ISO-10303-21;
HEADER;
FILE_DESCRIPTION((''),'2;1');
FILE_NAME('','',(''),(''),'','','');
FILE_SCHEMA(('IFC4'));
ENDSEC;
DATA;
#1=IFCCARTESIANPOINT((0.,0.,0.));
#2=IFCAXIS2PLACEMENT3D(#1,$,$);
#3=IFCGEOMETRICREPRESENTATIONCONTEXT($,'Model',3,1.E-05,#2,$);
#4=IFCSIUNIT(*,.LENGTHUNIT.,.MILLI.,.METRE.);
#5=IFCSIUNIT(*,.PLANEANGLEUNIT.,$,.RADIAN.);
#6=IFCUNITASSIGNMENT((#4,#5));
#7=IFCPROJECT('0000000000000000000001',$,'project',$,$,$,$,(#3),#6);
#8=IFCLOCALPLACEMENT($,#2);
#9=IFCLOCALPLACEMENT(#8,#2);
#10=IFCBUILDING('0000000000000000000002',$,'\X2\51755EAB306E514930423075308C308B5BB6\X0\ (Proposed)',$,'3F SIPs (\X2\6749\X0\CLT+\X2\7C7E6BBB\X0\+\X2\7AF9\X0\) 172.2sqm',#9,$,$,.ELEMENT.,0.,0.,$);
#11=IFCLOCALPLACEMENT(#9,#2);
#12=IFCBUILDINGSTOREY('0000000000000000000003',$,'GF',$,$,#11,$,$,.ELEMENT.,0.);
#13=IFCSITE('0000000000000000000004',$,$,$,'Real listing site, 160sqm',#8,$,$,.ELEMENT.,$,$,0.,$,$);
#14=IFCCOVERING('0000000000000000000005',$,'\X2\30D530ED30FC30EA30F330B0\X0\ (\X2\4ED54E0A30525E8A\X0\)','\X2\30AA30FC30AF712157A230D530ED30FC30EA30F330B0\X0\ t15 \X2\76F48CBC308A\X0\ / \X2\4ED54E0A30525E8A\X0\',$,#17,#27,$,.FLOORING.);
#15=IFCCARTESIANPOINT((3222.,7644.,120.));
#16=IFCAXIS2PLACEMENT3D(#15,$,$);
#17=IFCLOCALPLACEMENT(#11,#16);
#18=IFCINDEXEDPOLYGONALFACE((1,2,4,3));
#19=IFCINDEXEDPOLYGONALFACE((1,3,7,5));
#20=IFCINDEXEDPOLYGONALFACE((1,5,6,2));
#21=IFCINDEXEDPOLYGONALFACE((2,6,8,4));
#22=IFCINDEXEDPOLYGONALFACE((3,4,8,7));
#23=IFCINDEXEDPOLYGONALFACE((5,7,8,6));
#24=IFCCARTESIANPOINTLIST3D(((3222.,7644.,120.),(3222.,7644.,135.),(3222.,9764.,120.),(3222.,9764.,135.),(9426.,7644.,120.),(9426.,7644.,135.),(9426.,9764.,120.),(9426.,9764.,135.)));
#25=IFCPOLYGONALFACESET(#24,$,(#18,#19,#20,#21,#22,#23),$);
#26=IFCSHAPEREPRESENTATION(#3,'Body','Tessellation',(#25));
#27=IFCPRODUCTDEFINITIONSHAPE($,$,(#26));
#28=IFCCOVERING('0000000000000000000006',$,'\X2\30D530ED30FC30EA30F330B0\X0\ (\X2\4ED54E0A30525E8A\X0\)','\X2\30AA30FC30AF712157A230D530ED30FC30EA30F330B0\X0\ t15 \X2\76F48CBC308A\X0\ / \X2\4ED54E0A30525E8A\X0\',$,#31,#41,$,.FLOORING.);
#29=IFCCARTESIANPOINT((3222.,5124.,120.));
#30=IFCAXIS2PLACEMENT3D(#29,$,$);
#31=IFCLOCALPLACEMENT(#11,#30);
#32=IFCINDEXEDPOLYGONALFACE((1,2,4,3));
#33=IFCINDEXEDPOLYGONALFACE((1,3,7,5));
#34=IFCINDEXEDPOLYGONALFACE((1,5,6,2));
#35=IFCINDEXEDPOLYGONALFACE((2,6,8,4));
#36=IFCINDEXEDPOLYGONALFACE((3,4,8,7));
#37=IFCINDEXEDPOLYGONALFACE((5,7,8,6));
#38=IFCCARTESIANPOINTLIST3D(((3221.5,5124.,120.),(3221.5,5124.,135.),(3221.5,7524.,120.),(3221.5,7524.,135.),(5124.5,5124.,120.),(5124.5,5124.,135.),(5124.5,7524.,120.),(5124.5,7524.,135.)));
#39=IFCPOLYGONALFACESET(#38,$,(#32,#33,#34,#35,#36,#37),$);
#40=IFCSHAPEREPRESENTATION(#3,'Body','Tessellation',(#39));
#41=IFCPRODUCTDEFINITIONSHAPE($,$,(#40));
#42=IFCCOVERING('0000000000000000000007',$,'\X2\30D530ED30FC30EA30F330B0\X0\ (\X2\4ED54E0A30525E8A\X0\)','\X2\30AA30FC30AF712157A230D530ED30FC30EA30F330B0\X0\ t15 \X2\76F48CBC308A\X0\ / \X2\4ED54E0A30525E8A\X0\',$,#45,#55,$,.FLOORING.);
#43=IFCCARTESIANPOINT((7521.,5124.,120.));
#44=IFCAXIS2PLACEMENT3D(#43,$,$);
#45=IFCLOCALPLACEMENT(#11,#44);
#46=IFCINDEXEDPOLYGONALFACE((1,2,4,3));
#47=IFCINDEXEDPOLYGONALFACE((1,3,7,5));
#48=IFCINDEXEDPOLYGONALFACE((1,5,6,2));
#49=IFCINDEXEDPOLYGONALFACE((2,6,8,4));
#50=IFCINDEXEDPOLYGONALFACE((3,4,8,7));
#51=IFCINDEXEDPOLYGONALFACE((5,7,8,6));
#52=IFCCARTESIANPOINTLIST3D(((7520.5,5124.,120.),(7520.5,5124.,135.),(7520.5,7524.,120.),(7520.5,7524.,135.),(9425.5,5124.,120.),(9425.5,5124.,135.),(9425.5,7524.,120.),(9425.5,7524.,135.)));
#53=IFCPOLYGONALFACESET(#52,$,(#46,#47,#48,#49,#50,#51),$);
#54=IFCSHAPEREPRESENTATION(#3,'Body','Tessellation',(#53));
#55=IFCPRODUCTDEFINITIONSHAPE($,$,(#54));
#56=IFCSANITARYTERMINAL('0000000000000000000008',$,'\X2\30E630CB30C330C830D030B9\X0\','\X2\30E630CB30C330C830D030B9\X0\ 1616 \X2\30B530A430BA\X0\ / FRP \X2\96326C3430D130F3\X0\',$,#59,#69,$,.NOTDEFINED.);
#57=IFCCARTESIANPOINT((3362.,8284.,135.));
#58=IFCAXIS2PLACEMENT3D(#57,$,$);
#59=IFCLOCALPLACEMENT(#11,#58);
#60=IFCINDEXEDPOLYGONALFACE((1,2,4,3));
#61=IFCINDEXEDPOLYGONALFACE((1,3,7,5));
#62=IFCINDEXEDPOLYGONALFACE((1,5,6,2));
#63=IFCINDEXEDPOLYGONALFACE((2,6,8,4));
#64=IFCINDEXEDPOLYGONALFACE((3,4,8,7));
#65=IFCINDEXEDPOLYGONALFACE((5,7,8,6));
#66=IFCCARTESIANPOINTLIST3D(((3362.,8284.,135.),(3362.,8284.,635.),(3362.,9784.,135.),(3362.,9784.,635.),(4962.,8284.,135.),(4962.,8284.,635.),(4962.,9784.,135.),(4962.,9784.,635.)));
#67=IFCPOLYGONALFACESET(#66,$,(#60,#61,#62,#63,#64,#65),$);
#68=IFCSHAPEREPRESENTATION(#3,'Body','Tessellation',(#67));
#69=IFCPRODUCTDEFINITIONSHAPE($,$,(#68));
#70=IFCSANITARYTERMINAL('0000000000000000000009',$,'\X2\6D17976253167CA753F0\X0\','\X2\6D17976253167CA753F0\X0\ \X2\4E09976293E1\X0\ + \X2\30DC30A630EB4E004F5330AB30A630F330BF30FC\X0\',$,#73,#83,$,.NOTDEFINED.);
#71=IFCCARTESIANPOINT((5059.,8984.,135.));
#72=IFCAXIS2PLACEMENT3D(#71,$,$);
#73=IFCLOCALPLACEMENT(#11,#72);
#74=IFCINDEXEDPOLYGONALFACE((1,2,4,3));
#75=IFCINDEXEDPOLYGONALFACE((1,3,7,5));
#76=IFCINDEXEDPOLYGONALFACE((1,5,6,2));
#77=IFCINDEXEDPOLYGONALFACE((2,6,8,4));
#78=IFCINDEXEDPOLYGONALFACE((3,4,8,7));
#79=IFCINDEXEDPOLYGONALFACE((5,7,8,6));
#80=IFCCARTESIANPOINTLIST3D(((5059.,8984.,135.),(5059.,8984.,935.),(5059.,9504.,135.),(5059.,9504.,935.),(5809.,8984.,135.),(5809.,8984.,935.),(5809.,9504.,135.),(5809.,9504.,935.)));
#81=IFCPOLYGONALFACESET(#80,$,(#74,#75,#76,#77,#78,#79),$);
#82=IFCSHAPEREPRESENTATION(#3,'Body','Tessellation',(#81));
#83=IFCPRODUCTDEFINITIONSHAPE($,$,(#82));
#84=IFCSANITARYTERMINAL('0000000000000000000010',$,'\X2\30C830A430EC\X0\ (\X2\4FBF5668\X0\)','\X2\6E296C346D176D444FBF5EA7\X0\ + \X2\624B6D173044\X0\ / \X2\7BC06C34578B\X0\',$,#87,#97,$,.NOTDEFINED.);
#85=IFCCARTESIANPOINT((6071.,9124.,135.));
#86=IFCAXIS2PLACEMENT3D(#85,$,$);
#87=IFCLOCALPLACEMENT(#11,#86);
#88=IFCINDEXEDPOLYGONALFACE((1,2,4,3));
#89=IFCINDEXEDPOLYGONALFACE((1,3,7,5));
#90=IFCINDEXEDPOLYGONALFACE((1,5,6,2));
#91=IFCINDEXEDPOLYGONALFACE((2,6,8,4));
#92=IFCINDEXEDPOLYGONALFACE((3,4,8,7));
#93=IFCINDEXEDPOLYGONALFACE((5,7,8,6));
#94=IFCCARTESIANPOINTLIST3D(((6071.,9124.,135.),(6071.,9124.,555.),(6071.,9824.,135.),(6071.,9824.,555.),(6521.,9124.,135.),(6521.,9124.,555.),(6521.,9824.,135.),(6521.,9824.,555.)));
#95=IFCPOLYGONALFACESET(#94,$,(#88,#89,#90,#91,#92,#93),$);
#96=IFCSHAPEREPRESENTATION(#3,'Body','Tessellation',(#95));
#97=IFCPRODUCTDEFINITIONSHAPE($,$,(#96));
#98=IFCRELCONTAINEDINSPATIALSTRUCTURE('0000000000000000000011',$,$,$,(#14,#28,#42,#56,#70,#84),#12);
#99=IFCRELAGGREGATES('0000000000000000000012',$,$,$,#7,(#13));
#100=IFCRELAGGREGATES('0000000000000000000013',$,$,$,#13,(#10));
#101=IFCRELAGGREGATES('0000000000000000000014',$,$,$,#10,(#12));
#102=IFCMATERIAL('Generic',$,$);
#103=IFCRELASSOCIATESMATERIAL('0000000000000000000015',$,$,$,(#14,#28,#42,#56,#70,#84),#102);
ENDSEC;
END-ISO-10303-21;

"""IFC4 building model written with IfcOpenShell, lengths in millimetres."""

from ifc_helpers import new_model, si_unit, frame, frame_2d, origin, place, context, project, spatial, rectangle, extrude, material, element, save


model = new_model("IFC4")

# Units and contexts
model_context = context("Model", 3, precision=1e-05, world=origin())
ifc_project = project(units=[si_unit("LENGTHUNIT", "METRE", prefix="MILLI"), si_unit("PLANEANGLEUNIT", "RADIAN")], contexts=[model_context])

# Site, building, storey
site_placement = place(None, origin())
site = spatial("IfcSite", under=ifc_project, at=site_placement, ObjectType="Real listing site, 160sqm", CompositionType="ELEMENT", RefElevation=0.0)
building_placement = place(site_placement, origin())
building = spatial("IfcBuilding", under=site, at=building_placement, Name="兵庫の光あふれる家 (Proposed)", ObjectType="3F SIPs (杉CLT+籾殻+竹) 172.2sqm", CompositionType="ELEMENT", ElevationOfRefHeight=0.0, ElevationOfTerrain=0.0)
storey_placement = place(building_placement, origin())
storey = spatial("IfcBuildingStorey", under=building, at=storey_placement, Name="GF", CompositionType="ELEMENT", Elevation=0.0)

# Coverings
ifc_material_1 = material(Name="Generic")
covering_1_placement = place(storey_placement, frame((3222.0, 7644.0, 120.0)))
element("IfcCovering", 1, at=covering_1_placement, inside=storey, material=ifc_material_1, Name="フローリング (仕上げ床)", Description="オーク無垢フローリング t15 直貼り / 仕上げ床", PredefinedType="FLOORING", context=model_context, shape_type="SweptSolid", body=[
    extrude(rectangle(XDim=6204.0, YDim=2120.0, at=frame_2d((3102.0, 1060.0))), frame((3222.0, 7644.0, 120.0)), (0.0, 0.0, 1.0), 15.0),
])
covering_2_placement = place(storey_placement, frame((3222.0, 5124.0, 120.0)))
element("IfcCovering", 2, at=covering_2_placement, inside=storey, material=ifc_material_1, Name="フローリング (仕上げ床)", Description="オーク無垢フローリング t15 直貼り / 仕上げ床", PredefinedType="FLOORING", context=model_context, shape_type="SweptSolid", body=[
    extrude(rectangle(XDim=1903.0, YDim=2400.0, at=frame_2d((951.0, 1200.0))), frame((3222.0, 5124.0, 120.0)), (0.0, 0.0, 1.0), 15.0),
])
covering_3_placement = place(storey_placement, frame((7521.0, 5124.0, 120.0)))
element("IfcCovering", 3, at=covering_3_placement, inside=storey, material=ifc_material_1, Name="フローリング (仕上げ床)", Description="オーク無垢フローリング t15 直貼り / 仕上げ床", PredefinedType="FLOORING", context=model_context, shape_type="SweptSolid", body=[
    extrude(rectangle(XDim=1905.0, YDim=2400.0, at=frame_2d((952.0, 1200.0))), frame((7521.0, 5124.0, 120.0)), (0.0, 0.0, 1.0), 15.0),
])

# Sanitary terminals
sanitary_terminal_1_placement = place(storey_placement, frame((3362.0, 8284.0, 135.0)))
element("IfcSanitaryTerminal", 4, at=sanitary_terminal_1_placement, inside=storey, material=ifc_material_1, Name="ユニットバス", Description="ユニットバス 1616 サイズ / FRP 防水パン", PredefinedType="NOTDEFINED", context=model_context, shape_type="SweptSolid", body=[
    extrude(rectangle(XDim=1600.0, YDim=1500.0, at=frame_2d((800.0, 750.0))), frame((3362.0, 8284.0, 135.0)), (0.0, 0.0, 1.0), 500.0),
])
sanitary_terminal_2_placement = place(storey_placement, frame((5059.0, 8984.0, 135.0)))
element("IfcSanitaryTerminal", 5, at=sanitary_terminal_2_placement, inside=storey, material=ifc_material_1, Name="洗面化粧台", Description="洗面化粧台 三面鏡 + ボウル一体カウンター", PredefinedType="NOTDEFINED", context=model_context, shape_type="SweptSolid", body=[
    extrude(rectangle(XDim=750.0, YDim=520.0, at=frame_2d((375.0, 260.0))), frame((5059.0, 8984.0, 135.0)), (0.0, 0.0, 1.0), 800.0),
])
sanitary_terminal_3_placement = place(storey_placement, frame((6071.0, 9124.0, 135.0)))
element("IfcSanitaryTerminal", 6, at=sanitary_terminal_3_placement, inside=storey, material=ifc_material_1, Name="トイレ (便器)", Description="温水洗浄便座 + 手洗い / 節水型", PredefinedType="NOTDEFINED", context=model_context, shape_type="SweptSolid", body=[
    extrude(rectangle(XDim=450.0, YDim=700.0, at=frame_2d((225.0, 350.0))), frame((6071.0, 9124.0, 135.0)), (0.0, 0.0, 1.0), 420.0),
])

save(model, "model.ifc")
